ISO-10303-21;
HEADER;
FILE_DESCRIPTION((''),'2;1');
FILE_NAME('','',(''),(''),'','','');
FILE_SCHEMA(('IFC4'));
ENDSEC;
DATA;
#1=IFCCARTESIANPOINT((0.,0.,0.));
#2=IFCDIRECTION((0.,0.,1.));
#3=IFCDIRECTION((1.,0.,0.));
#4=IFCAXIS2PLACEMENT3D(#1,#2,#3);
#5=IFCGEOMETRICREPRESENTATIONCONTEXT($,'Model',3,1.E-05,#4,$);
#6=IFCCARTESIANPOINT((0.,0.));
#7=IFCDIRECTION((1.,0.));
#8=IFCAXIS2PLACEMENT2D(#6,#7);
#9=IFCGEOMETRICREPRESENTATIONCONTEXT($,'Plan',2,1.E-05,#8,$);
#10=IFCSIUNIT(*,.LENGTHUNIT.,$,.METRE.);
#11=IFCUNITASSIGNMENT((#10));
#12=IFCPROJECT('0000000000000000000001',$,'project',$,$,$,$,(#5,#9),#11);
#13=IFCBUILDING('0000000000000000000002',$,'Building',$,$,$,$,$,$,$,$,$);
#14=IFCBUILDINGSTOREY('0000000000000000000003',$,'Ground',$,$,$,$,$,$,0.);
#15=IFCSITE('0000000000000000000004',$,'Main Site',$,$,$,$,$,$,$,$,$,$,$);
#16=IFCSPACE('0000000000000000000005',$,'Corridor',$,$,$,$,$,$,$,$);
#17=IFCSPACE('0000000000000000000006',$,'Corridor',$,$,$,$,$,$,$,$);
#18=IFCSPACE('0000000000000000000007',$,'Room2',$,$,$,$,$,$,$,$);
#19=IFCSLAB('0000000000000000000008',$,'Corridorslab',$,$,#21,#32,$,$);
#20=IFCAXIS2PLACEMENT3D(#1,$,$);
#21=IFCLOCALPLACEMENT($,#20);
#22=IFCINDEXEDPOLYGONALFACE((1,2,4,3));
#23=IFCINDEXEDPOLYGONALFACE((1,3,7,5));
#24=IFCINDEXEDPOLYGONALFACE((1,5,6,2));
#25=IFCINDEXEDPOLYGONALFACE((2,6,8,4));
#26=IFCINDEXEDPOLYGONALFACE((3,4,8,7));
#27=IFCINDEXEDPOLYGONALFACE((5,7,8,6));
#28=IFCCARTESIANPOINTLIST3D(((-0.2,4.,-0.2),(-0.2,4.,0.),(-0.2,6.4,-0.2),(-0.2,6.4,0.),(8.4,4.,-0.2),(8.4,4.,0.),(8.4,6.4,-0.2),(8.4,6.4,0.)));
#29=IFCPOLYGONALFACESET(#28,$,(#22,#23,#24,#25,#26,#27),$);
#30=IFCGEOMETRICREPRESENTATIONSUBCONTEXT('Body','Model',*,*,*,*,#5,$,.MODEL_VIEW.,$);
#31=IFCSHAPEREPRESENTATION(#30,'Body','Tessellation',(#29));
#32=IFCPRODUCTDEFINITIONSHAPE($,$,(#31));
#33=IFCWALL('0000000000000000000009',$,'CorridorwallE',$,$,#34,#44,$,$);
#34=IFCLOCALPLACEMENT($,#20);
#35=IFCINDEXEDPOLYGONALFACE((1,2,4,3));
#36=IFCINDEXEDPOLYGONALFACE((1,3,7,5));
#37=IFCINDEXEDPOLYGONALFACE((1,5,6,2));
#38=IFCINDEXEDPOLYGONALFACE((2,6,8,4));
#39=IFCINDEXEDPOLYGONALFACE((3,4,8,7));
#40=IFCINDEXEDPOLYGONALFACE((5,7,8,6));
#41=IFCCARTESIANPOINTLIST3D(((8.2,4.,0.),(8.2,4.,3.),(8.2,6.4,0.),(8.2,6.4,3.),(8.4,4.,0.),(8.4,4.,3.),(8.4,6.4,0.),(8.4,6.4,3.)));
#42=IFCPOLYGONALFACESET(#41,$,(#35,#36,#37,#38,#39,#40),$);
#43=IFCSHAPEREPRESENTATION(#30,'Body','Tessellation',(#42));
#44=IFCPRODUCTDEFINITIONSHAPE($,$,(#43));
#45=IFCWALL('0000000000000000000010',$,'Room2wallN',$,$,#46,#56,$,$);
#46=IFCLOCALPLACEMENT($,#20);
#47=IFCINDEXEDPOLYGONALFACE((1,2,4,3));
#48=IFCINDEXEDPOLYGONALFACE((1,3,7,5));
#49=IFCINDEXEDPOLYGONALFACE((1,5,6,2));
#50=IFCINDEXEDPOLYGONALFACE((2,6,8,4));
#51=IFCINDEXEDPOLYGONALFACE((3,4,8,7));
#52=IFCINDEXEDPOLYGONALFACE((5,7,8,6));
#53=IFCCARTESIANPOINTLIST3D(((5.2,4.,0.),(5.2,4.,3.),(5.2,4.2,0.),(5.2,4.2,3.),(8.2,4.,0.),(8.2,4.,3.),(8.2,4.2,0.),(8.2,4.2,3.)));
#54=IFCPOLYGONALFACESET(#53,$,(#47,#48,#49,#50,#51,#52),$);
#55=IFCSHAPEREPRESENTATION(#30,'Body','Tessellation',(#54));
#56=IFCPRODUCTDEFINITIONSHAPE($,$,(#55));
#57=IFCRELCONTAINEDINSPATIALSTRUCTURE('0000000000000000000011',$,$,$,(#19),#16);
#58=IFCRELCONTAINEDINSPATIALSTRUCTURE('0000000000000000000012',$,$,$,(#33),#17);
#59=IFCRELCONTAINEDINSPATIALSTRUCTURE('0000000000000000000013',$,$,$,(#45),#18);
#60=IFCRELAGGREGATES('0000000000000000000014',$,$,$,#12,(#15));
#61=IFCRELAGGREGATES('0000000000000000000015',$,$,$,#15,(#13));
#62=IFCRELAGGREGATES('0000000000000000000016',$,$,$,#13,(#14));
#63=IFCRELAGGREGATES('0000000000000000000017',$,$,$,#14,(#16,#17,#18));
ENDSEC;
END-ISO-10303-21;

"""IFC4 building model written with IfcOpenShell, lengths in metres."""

from ifc_helpers import new_model, si_unit, frame, origin_with_axes, origin_2d_with_axis, place, context, subcontext, project, spatial, indexed_curve, rectangle, outline, extrude, element, save


model = new_model("IFC4")

# Units and contexts
model_context = context("Model", 3, precision=1e-05, world=origin_with_axes())
plan_context = context("Plan", 2, precision=1e-05, world=origin_2d_with_axis())
body_context = subcontext(model_context, "Body", "Model", "MODEL_VIEW")
ifc_project = project(units=[si_unit("LENGTHUNIT", "METRE")], contexts=[model_context, plan_context])

# Site, building, storey, space
site = spatial("IfcSite", under=ifc_project, Name="Main Site")
building = spatial("IfcBuilding", under=site, Name="Building")
storey = spatial("IfcBuildingStorey", under=building, Name="Ground", Elevation=0.0)
space_1 = spatial("IfcSpace", under=storey, Name="Corridor")

# Slab
slab_1_placement = place(None, frame((4.1, 5.2, -0.2), z_axis=(0.0, 0.0, 1.0), x_axis=(1.0, 0.0, 0.0)))
element("IfcSlab", 1, at=slab_1_placement, inside=space_1, Name="Corridorslab", context=body_context, shape_type="SweptSolid", body=[
    extrude(rectangle(XDim=8.6, YDim=2.4), origin_with_axes(), (0.0, 0.0, 1.0), 0.2),
])

# Shared definitions
space_2 = spatial("IfcSpace", under=storey, Name="Corridor")

# Wall
wall_1_placement = place(None, frame((8.4, 4.0, 0.0), z_axis=(0.0, 0.0, 1.0), x_axis=(0.0, 1.0, 0.0)))
element("IfcWall", 2, at=wall_1_placement, inside=space_2, Name="CorridorwallE", context=body_context, shape_type="SweptSolid", body=[
    extrude(outline(indexed_curve([(0.0, 0.0), (0.0, 0.2), (2.4, 0.2), (2.4, 0.0), (0.0, 0.0)], self_intersect=False)), origin_with_axes(), (0.0, 0.0, 1.0), 3.0),
])

# Shared definitions
space_3 = spatial("IfcSpace", under=storey, Name="Room2")

# Wall
wall_2_placement = place(None, frame((5.2, 4.0, 0.0), z_axis=(0.0, 0.0, 1.0), x_axis=(1.0, 0.0, 0.0)))
element("IfcWall", 3, at=wall_2_placement, inside=space_3, Name="Room2wallN", context=body_context, shape_type="SweptSolid", body=[
    extrude(outline(indexed_curve([(0.0, 0.0), (0.0, 0.2), (3.0, 0.2), (3.0, 0.0), (0.0, 0.0)], self_intersect=False)), origin_with_axes(), (0.0, 0.0, 1.0), 3.0),
])

save(model, "model.ifc")
